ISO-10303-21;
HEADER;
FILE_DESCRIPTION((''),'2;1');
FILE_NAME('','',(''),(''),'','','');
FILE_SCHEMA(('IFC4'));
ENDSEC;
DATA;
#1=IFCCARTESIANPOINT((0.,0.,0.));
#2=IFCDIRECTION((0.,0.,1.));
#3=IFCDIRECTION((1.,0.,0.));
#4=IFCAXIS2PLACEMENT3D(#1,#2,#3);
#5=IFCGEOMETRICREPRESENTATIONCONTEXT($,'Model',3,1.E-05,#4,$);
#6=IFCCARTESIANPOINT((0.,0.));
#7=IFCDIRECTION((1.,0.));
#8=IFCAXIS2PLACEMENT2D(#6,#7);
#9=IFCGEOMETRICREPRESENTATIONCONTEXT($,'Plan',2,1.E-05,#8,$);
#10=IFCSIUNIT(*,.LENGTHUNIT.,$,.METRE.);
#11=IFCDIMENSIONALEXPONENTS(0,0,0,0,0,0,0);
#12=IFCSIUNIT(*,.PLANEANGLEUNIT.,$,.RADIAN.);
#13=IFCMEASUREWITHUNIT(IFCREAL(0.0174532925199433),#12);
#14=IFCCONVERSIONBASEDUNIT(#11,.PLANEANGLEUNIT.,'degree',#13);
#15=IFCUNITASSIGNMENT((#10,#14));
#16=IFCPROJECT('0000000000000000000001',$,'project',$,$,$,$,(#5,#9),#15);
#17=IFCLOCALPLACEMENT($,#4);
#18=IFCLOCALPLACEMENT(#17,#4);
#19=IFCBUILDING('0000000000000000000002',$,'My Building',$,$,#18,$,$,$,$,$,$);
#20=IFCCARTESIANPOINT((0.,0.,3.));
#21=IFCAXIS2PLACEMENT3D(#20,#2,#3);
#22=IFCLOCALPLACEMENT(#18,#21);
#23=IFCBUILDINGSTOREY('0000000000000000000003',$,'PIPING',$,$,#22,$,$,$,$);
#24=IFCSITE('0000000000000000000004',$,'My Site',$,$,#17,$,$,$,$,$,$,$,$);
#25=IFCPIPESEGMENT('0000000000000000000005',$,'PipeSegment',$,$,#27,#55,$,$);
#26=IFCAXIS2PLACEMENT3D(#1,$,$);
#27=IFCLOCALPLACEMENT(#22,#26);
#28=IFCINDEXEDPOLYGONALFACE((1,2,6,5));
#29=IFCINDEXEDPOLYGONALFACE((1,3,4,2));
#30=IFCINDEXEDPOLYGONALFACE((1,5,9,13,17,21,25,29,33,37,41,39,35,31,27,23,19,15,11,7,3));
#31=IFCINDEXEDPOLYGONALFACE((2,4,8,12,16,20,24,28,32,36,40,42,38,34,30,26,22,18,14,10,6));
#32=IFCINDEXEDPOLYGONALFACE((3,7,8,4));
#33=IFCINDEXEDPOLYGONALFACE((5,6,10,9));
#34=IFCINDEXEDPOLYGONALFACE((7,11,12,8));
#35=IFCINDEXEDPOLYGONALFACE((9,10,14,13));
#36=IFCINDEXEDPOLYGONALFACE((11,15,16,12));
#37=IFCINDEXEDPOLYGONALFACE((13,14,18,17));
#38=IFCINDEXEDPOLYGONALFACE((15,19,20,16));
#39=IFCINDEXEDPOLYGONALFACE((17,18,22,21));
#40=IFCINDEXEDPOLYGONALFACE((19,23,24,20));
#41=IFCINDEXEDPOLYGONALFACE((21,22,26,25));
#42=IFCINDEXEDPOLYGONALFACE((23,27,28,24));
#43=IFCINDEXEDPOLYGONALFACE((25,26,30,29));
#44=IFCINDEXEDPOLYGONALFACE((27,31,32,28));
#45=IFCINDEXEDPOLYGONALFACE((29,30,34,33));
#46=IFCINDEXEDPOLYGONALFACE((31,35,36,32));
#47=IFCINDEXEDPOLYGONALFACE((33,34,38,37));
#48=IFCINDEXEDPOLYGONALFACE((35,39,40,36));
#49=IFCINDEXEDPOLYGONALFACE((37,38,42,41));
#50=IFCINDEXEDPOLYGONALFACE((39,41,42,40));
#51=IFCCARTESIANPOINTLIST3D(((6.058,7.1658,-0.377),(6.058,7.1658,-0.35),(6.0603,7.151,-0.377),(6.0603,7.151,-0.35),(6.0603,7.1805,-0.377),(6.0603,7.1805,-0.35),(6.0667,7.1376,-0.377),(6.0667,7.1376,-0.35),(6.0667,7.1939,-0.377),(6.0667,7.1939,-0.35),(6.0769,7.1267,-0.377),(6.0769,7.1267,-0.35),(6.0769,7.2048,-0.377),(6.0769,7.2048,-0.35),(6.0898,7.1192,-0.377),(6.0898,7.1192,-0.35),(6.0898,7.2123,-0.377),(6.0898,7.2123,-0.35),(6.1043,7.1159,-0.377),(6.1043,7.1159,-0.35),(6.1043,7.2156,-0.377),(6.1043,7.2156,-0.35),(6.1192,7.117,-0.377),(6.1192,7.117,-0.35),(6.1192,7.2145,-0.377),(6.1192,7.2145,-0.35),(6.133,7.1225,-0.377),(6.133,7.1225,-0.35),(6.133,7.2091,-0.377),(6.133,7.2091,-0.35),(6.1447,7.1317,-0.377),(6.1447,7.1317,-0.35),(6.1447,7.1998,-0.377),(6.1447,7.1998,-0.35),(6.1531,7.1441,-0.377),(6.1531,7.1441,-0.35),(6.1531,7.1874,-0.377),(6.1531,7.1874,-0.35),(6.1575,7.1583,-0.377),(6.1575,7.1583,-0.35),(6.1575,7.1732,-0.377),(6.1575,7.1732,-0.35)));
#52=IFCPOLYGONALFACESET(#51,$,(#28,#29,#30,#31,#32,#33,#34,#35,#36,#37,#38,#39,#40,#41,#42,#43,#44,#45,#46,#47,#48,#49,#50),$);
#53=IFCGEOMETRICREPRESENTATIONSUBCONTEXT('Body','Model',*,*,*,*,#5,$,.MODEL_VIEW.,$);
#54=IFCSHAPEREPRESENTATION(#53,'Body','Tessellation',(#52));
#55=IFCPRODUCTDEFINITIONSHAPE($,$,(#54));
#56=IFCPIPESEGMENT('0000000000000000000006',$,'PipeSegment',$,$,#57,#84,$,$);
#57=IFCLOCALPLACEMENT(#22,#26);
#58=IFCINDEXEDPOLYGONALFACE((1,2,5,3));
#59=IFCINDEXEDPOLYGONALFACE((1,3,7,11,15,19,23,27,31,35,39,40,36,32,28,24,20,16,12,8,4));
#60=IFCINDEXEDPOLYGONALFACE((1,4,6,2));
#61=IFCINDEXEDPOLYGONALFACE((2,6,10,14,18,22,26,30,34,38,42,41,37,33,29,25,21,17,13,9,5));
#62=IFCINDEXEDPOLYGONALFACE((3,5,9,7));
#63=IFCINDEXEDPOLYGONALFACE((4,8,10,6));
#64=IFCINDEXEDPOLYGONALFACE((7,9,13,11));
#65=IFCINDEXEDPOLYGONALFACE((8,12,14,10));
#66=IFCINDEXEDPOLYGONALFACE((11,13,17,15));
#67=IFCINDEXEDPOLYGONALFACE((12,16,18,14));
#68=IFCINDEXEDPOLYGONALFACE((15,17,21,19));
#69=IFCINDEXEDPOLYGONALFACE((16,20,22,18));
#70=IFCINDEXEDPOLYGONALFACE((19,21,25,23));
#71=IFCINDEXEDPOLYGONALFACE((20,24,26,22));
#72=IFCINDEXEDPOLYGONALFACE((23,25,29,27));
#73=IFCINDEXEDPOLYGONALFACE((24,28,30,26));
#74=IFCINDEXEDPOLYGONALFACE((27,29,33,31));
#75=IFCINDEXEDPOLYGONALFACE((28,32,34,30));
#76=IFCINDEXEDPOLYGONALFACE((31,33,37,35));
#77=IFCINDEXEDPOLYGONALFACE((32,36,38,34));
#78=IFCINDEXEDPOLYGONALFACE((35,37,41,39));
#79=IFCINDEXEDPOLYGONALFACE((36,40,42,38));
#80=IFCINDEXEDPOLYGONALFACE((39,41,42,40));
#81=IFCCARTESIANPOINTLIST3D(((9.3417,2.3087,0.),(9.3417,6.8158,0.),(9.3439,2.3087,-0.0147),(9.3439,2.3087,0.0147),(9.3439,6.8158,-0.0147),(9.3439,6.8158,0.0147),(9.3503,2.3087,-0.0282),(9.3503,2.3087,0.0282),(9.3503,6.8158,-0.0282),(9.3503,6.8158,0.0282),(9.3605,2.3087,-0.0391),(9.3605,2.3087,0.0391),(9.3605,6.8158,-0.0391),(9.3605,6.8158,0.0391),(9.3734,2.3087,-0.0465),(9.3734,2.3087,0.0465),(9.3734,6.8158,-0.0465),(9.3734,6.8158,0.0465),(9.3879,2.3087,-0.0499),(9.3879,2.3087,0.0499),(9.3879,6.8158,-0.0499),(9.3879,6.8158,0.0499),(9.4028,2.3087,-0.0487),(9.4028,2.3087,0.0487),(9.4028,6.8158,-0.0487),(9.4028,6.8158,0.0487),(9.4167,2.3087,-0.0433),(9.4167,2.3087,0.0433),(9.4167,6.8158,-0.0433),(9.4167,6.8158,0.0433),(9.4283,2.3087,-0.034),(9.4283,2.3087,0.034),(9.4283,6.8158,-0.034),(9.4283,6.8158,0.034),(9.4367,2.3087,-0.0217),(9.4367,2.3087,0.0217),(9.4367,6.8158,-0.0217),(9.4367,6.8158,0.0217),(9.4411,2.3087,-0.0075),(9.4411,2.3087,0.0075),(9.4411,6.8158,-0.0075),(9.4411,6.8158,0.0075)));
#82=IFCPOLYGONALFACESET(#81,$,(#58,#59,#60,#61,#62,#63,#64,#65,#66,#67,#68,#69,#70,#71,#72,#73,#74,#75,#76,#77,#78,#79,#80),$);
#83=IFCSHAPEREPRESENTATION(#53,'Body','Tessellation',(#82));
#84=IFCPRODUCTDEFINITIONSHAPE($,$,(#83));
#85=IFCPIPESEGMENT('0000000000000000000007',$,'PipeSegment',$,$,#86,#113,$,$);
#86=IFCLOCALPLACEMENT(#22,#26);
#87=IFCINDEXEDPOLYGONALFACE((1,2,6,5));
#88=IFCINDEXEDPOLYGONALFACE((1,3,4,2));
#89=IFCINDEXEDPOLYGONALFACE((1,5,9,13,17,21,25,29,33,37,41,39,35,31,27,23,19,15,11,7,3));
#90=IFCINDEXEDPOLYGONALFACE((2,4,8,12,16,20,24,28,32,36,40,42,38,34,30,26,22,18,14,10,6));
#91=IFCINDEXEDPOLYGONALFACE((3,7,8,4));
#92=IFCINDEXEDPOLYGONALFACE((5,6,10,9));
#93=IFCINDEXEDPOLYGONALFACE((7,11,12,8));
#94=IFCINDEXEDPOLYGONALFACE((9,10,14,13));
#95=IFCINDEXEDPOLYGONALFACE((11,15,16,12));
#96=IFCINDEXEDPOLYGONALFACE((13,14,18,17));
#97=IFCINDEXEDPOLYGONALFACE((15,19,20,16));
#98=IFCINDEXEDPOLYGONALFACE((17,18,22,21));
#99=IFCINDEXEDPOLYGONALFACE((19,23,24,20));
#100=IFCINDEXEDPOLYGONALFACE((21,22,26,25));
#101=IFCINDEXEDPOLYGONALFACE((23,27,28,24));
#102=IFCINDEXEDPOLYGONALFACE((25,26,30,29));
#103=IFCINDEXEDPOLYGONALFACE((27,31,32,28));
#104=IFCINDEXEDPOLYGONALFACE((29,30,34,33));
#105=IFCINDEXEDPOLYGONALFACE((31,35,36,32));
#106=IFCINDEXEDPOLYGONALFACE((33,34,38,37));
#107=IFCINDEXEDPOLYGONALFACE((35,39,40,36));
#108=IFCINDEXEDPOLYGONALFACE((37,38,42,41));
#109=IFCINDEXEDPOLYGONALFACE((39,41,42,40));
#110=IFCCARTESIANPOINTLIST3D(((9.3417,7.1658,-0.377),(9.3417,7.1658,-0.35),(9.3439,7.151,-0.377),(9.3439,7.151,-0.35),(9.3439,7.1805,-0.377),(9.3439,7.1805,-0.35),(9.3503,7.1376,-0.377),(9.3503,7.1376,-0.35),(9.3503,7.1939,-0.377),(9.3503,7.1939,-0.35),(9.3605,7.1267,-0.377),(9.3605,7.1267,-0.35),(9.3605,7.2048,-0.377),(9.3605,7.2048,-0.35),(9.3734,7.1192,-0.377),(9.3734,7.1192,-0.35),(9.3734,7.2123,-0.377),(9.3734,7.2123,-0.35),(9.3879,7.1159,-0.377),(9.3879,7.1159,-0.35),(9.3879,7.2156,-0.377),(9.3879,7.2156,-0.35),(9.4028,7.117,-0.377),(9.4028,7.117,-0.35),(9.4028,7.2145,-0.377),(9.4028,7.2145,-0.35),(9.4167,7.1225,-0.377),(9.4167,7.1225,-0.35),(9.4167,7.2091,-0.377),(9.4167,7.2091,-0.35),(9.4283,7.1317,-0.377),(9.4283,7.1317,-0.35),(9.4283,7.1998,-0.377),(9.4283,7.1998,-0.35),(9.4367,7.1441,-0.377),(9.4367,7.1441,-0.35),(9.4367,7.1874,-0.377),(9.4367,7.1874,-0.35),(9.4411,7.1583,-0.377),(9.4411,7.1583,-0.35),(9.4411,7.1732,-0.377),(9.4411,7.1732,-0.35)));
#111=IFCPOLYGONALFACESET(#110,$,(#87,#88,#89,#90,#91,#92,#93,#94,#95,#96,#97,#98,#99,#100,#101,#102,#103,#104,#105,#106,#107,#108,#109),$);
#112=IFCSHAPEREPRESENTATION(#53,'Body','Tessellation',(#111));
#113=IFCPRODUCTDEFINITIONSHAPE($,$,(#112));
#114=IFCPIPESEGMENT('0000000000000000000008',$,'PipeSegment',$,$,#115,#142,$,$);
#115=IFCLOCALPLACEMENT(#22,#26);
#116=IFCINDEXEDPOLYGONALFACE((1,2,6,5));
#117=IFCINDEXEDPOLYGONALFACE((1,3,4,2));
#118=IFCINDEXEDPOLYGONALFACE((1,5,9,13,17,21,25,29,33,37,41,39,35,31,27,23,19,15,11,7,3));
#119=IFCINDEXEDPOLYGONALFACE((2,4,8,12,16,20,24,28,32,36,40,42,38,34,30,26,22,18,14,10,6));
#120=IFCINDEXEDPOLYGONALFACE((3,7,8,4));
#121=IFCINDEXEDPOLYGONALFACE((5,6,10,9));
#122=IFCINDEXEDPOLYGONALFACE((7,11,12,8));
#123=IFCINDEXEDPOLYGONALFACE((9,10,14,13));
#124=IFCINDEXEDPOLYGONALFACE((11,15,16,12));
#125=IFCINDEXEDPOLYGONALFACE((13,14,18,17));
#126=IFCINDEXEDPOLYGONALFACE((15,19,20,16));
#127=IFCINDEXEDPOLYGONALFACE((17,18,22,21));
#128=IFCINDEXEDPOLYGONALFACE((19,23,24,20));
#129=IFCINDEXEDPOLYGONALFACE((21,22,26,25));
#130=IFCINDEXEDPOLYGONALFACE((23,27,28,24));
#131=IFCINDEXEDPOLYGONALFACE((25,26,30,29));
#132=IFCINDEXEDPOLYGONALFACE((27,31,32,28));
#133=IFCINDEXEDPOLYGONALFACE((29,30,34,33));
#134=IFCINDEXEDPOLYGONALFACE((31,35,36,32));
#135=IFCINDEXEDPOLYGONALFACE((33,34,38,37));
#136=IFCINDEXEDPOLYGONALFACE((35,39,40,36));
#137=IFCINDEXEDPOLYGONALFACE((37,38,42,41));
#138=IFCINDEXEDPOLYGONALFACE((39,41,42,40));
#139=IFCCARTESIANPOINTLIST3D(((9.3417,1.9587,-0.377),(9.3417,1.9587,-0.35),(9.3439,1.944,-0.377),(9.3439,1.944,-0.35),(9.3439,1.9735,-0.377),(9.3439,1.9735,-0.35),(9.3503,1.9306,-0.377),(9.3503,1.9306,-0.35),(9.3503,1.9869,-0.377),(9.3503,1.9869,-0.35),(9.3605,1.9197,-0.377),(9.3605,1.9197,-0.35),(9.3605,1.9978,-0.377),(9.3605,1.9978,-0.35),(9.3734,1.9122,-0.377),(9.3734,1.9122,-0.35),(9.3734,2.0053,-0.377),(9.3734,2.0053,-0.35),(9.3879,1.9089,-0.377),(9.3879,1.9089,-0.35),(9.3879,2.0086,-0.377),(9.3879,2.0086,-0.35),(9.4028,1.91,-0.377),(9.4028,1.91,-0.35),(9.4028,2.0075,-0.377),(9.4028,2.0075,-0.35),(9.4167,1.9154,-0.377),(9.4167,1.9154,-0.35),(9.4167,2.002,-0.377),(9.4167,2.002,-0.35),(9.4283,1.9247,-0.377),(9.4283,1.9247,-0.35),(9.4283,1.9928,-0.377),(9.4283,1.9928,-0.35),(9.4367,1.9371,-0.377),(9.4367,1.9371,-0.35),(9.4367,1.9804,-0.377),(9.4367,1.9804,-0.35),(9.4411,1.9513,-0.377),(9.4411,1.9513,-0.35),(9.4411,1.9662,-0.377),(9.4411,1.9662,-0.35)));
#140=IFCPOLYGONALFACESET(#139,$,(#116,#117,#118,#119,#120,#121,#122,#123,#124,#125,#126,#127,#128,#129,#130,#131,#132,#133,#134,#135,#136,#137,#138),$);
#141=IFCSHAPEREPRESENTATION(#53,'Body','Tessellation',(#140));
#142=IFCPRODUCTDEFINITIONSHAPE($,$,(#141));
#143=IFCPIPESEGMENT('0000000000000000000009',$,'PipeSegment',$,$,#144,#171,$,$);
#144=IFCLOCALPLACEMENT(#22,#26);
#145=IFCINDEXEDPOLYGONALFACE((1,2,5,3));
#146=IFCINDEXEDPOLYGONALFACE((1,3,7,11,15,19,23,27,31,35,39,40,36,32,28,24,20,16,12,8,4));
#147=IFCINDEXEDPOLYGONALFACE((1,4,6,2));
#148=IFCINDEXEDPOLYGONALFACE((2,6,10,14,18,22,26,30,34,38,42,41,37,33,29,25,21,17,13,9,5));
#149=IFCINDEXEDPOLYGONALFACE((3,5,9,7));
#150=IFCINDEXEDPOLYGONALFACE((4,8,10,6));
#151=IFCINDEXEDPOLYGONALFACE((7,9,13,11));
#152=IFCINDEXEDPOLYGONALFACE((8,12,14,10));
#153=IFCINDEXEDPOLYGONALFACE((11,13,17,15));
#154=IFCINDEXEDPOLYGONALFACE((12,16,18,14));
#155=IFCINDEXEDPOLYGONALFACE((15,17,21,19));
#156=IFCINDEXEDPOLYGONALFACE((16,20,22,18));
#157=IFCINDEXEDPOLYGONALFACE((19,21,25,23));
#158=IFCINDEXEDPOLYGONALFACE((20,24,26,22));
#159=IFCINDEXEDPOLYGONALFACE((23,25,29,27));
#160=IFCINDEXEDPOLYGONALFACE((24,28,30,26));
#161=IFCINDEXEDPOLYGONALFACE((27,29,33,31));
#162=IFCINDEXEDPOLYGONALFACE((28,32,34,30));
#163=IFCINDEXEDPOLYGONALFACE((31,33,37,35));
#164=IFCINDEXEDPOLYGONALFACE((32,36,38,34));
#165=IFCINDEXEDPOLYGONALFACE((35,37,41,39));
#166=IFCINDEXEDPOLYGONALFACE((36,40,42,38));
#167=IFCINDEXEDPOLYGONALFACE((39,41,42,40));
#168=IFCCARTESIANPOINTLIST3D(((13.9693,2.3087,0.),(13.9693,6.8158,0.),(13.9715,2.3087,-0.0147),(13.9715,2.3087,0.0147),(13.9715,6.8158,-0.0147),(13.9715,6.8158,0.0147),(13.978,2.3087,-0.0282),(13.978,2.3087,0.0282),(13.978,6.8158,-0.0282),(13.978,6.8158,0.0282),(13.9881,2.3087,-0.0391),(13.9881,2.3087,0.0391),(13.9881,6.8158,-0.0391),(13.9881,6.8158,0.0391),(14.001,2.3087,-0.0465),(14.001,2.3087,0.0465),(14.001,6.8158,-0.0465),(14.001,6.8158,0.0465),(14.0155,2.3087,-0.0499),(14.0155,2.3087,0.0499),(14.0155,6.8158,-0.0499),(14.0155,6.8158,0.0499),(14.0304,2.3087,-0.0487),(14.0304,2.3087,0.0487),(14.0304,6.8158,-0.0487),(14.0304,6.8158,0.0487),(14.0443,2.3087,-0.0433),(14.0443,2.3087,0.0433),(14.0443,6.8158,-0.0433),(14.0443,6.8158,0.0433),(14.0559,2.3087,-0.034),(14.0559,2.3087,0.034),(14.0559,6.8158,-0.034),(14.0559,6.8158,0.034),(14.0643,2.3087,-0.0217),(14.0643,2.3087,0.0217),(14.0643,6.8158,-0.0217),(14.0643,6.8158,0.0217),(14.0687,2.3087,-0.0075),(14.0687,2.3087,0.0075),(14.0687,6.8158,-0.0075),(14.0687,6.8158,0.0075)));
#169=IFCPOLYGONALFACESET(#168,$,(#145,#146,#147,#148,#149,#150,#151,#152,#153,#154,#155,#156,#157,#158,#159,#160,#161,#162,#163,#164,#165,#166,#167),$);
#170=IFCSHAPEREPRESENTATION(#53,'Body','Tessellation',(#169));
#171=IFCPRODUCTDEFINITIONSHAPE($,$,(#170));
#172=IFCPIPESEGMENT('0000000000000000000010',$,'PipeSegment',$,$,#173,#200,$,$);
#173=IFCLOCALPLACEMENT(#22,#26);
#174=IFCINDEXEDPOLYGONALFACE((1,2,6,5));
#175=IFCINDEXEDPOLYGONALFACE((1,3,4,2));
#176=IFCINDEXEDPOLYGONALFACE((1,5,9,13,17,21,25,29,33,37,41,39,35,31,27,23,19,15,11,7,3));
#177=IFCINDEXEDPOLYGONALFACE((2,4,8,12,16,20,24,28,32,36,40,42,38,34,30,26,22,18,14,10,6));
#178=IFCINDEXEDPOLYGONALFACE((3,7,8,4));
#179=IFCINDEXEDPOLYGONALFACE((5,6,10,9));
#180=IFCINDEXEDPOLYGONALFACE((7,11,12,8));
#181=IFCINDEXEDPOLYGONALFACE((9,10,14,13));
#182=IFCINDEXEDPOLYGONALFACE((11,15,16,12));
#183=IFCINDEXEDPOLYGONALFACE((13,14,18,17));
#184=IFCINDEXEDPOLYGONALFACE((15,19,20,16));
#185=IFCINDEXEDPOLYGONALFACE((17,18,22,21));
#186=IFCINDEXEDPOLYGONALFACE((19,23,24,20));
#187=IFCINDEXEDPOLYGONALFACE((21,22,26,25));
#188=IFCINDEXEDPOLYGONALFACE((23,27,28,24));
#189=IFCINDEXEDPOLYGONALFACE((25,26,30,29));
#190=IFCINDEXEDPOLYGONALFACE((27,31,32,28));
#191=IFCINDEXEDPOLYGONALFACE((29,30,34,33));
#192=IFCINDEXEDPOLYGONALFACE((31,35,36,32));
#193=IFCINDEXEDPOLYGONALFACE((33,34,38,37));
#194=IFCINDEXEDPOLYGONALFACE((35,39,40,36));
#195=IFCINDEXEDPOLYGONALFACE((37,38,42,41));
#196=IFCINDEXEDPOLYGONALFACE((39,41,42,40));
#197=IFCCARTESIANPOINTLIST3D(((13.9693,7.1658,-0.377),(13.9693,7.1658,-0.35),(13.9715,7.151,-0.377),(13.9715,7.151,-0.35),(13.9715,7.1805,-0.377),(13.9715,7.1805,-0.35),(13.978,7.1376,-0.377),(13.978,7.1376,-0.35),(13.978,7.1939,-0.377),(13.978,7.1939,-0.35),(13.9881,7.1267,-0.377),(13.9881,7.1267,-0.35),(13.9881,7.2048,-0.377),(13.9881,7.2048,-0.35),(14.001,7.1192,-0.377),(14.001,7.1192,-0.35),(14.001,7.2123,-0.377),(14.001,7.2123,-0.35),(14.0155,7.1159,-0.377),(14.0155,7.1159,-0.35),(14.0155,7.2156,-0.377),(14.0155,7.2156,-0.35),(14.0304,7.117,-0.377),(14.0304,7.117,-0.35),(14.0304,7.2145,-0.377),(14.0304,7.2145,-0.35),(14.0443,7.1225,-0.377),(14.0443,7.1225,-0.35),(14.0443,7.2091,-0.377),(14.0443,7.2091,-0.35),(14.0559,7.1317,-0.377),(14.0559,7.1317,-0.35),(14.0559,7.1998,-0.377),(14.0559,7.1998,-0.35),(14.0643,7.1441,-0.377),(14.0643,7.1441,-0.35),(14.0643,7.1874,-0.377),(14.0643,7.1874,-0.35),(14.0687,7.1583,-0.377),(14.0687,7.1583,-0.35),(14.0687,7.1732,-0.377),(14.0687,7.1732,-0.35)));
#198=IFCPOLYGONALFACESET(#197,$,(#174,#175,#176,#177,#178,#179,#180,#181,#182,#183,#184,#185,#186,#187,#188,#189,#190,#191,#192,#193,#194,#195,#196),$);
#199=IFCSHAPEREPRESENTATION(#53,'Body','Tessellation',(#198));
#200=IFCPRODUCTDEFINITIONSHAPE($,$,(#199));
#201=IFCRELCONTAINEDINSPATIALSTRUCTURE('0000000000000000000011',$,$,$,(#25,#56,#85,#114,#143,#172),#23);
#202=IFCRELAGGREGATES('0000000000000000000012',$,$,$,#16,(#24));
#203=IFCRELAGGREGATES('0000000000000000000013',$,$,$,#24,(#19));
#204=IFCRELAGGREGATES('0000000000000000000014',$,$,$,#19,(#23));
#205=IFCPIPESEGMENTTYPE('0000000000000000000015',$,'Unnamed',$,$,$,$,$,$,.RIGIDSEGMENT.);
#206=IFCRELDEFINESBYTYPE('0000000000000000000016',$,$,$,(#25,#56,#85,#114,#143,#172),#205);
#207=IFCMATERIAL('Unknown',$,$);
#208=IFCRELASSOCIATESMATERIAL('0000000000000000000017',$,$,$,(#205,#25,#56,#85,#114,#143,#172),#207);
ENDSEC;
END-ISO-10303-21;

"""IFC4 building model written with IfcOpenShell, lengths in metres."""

from ifc_helpers import new_model, entity, si_unit, converted_unit, frame, origin_with_axes, origin_2d_with_axis, place, context, subcontext, project, spatial, circle, extrude, material, material_profile, profile_set, profile_usage, type_object, element, save


model = new_model("IFC4")

# Units and contexts
model_context = context("Model", 3, precision=1e-05, world=origin_with_axes())
plan_context = context("Plan", 2, precision=1e-05, world=origin_2d_with_axis())
body_context = subcontext(model_context, "Body", "Model", "MODEL_VIEW")
ifc_project = project(units=[si_unit("LENGTHUNIT", "METRE"), converted_unit("PLANEANGLEUNIT", "degree", entity("IfcReal", 0.0174532925199433), si_unit("PLANEANGLEUNIT", "RADIAN"), dimensions=[0, 0, 0, 0, 0, 0, 0])], contexts=[model_context, plan_context])

# Site, building, storey
site_placement = place(None, origin_with_axes())
site = spatial("IfcSite", under=ifc_project, at=site_placement, Name="My Site")
building_placement = place(site_placement, origin_with_axes())
building = spatial("IfcBuilding", under=site, at=building_placement, Name="My Building")
storey_placement = place(building_placement, frame((0.0, 0.0, 3.0), z_axis=(0.0, 0.0, 1.0), x_axis=(1.0, 0.0, 0.0)))
storey = spatial("IfcBuildingStorey", under=building, at=storey_placement, Name="PIPING")

# Pipe segments
ifc_material = material(Name="Unknown")
ifc_material_profile = material_profile(ifc_material, circle(Radius=0.05))
ifc_profile_set = profile_set([ifc_material_profile])
pipe_segment_type = type_object("IfcPipeSegmentType", Name="Unnamed", PredefinedType="RIGIDSEGMENT", material=ifc_profile_set)
ifc_profile_usage_1 = profile_usage(ifc_profile_set, cardinal=5)
pipe_segment_1_placement = place(storey_placement, frame((6.108, 7.1658, -0.35), z_axis=(0.0, 0.0, -1.0), x_axis=(-1.0, 0.0, 0.0)))
element("IfcPipeSegment", 1, at=pipe_segment_1_placement, inside=storey, type_object=pipe_segment_type, material=ifc_profile_usage_1, Name="PipeSegment", context=body_context, shape_type="SweptSolid", body=[
    extrude(circle(Radius=0.05), origin_with_axes(), (0.0, 0.0, 1.0), 0.027),
])
ifc_profile_usage_2 = profile_usage(ifc_profile_set, cardinal=5)
pipe_segment_2_placement = place(storey_placement, frame((9.3917, 2.3087, 0.0), z_axis=(0.0, 1.0, 0.0), x_axis=(-1.0, 0.0, 0.0)))
element("IfcPipeSegment", 2, at=pipe_segment_2_placement, inside=storey, type_object=pipe_segment_type, material=ifc_profile_usage_2, Name="PipeSegment", context=body_context, shape_type="SweptSolid", body=[
    extrude(circle(Radius=0.05), origin_with_axes(), (0.0, 0.0, 1.0), 4.507),
])
ifc_profile_usage_3 = profile_usage(ifc_profile_set, cardinal=5)
pipe_segment_3_placement = place(storey_placement, frame((9.3917, 7.1658, -0.35), z_axis=(0.0, 0.0, -1.0), x_axis=(-1.0, 0.0, 0.0)))
element("IfcPipeSegment", 3, at=pipe_segment_3_placement, inside=storey, type_object=pipe_segment_type, material=ifc_profile_usage_3, Name="PipeSegment", context=body_context, shape_type="SweptSolid", body=[
    extrude(circle(Radius=0.05), origin_with_axes(), (0.0, 0.0, 1.0), 0.027),
])
ifc_profile_usage_4 = profile_usage(ifc_profile_set, cardinal=5)
pipe_segment_4_placement = place(storey_placement, frame((9.3917, 1.9587, -0.35), z_axis=(0.0, 0.0, -1.0), x_axis=(-1.0, 0.0, 0.0)))
element("IfcPipeSegment", 4, at=pipe_segment_4_placement, inside=storey, type_object=pipe_segment_type, material=ifc_profile_usage_4, Name="PipeSegment", context=body_context, shape_type="SweptSolid", body=[
    extrude(circle(Radius=0.05), origin_with_axes(), (0.0, 0.0, 1.0), 0.027),
])
ifc_profile_usage_5 = profile_usage(ifc_profile_set, cardinal=5)
pipe_segment_5_placement = place(storey_placement, frame((14.0193, 2.3087, 0.0), z_axis=(0.0, 1.0, 0.0), x_axis=(-1.0, 0.0, 0.0)))
element("IfcPipeSegment", 5, at=pipe_segment_5_placement, inside=storey, type_object=pipe_segment_type, material=ifc_profile_usage_5, Name="PipeSegment", context=body_context, shape_type="SweptSolid", body=[
    extrude(circle(Radius=0.05), origin_with_axes(), (0.0, 0.0, 1.0), 4.507),
])
ifc_profile_usage_6 = profile_usage(ifc_profile_set, cardinal=5)
pipe_segment_6_placement = place(storey_placement, frame((14.0193, 7.1658, -0.35), z_axis=(0.0, 0.0, -1.0), x_axis=(-1.0, 0.0, 0.0)))
element("IfcPipeSegment", 6, at=pipe_segment_6_placement, inside=storey, type_object=pipe_segment_type, material=ifc_profile_usage_6, Name="PipeSegment", context=body_context, shape_type="SweptSolid", body=[
    extrude(circle(Radius=0.05), origin_with_axes(), (0.0, 0.0, 1.0), 0.027),
])

save(model, "model.ifc")
